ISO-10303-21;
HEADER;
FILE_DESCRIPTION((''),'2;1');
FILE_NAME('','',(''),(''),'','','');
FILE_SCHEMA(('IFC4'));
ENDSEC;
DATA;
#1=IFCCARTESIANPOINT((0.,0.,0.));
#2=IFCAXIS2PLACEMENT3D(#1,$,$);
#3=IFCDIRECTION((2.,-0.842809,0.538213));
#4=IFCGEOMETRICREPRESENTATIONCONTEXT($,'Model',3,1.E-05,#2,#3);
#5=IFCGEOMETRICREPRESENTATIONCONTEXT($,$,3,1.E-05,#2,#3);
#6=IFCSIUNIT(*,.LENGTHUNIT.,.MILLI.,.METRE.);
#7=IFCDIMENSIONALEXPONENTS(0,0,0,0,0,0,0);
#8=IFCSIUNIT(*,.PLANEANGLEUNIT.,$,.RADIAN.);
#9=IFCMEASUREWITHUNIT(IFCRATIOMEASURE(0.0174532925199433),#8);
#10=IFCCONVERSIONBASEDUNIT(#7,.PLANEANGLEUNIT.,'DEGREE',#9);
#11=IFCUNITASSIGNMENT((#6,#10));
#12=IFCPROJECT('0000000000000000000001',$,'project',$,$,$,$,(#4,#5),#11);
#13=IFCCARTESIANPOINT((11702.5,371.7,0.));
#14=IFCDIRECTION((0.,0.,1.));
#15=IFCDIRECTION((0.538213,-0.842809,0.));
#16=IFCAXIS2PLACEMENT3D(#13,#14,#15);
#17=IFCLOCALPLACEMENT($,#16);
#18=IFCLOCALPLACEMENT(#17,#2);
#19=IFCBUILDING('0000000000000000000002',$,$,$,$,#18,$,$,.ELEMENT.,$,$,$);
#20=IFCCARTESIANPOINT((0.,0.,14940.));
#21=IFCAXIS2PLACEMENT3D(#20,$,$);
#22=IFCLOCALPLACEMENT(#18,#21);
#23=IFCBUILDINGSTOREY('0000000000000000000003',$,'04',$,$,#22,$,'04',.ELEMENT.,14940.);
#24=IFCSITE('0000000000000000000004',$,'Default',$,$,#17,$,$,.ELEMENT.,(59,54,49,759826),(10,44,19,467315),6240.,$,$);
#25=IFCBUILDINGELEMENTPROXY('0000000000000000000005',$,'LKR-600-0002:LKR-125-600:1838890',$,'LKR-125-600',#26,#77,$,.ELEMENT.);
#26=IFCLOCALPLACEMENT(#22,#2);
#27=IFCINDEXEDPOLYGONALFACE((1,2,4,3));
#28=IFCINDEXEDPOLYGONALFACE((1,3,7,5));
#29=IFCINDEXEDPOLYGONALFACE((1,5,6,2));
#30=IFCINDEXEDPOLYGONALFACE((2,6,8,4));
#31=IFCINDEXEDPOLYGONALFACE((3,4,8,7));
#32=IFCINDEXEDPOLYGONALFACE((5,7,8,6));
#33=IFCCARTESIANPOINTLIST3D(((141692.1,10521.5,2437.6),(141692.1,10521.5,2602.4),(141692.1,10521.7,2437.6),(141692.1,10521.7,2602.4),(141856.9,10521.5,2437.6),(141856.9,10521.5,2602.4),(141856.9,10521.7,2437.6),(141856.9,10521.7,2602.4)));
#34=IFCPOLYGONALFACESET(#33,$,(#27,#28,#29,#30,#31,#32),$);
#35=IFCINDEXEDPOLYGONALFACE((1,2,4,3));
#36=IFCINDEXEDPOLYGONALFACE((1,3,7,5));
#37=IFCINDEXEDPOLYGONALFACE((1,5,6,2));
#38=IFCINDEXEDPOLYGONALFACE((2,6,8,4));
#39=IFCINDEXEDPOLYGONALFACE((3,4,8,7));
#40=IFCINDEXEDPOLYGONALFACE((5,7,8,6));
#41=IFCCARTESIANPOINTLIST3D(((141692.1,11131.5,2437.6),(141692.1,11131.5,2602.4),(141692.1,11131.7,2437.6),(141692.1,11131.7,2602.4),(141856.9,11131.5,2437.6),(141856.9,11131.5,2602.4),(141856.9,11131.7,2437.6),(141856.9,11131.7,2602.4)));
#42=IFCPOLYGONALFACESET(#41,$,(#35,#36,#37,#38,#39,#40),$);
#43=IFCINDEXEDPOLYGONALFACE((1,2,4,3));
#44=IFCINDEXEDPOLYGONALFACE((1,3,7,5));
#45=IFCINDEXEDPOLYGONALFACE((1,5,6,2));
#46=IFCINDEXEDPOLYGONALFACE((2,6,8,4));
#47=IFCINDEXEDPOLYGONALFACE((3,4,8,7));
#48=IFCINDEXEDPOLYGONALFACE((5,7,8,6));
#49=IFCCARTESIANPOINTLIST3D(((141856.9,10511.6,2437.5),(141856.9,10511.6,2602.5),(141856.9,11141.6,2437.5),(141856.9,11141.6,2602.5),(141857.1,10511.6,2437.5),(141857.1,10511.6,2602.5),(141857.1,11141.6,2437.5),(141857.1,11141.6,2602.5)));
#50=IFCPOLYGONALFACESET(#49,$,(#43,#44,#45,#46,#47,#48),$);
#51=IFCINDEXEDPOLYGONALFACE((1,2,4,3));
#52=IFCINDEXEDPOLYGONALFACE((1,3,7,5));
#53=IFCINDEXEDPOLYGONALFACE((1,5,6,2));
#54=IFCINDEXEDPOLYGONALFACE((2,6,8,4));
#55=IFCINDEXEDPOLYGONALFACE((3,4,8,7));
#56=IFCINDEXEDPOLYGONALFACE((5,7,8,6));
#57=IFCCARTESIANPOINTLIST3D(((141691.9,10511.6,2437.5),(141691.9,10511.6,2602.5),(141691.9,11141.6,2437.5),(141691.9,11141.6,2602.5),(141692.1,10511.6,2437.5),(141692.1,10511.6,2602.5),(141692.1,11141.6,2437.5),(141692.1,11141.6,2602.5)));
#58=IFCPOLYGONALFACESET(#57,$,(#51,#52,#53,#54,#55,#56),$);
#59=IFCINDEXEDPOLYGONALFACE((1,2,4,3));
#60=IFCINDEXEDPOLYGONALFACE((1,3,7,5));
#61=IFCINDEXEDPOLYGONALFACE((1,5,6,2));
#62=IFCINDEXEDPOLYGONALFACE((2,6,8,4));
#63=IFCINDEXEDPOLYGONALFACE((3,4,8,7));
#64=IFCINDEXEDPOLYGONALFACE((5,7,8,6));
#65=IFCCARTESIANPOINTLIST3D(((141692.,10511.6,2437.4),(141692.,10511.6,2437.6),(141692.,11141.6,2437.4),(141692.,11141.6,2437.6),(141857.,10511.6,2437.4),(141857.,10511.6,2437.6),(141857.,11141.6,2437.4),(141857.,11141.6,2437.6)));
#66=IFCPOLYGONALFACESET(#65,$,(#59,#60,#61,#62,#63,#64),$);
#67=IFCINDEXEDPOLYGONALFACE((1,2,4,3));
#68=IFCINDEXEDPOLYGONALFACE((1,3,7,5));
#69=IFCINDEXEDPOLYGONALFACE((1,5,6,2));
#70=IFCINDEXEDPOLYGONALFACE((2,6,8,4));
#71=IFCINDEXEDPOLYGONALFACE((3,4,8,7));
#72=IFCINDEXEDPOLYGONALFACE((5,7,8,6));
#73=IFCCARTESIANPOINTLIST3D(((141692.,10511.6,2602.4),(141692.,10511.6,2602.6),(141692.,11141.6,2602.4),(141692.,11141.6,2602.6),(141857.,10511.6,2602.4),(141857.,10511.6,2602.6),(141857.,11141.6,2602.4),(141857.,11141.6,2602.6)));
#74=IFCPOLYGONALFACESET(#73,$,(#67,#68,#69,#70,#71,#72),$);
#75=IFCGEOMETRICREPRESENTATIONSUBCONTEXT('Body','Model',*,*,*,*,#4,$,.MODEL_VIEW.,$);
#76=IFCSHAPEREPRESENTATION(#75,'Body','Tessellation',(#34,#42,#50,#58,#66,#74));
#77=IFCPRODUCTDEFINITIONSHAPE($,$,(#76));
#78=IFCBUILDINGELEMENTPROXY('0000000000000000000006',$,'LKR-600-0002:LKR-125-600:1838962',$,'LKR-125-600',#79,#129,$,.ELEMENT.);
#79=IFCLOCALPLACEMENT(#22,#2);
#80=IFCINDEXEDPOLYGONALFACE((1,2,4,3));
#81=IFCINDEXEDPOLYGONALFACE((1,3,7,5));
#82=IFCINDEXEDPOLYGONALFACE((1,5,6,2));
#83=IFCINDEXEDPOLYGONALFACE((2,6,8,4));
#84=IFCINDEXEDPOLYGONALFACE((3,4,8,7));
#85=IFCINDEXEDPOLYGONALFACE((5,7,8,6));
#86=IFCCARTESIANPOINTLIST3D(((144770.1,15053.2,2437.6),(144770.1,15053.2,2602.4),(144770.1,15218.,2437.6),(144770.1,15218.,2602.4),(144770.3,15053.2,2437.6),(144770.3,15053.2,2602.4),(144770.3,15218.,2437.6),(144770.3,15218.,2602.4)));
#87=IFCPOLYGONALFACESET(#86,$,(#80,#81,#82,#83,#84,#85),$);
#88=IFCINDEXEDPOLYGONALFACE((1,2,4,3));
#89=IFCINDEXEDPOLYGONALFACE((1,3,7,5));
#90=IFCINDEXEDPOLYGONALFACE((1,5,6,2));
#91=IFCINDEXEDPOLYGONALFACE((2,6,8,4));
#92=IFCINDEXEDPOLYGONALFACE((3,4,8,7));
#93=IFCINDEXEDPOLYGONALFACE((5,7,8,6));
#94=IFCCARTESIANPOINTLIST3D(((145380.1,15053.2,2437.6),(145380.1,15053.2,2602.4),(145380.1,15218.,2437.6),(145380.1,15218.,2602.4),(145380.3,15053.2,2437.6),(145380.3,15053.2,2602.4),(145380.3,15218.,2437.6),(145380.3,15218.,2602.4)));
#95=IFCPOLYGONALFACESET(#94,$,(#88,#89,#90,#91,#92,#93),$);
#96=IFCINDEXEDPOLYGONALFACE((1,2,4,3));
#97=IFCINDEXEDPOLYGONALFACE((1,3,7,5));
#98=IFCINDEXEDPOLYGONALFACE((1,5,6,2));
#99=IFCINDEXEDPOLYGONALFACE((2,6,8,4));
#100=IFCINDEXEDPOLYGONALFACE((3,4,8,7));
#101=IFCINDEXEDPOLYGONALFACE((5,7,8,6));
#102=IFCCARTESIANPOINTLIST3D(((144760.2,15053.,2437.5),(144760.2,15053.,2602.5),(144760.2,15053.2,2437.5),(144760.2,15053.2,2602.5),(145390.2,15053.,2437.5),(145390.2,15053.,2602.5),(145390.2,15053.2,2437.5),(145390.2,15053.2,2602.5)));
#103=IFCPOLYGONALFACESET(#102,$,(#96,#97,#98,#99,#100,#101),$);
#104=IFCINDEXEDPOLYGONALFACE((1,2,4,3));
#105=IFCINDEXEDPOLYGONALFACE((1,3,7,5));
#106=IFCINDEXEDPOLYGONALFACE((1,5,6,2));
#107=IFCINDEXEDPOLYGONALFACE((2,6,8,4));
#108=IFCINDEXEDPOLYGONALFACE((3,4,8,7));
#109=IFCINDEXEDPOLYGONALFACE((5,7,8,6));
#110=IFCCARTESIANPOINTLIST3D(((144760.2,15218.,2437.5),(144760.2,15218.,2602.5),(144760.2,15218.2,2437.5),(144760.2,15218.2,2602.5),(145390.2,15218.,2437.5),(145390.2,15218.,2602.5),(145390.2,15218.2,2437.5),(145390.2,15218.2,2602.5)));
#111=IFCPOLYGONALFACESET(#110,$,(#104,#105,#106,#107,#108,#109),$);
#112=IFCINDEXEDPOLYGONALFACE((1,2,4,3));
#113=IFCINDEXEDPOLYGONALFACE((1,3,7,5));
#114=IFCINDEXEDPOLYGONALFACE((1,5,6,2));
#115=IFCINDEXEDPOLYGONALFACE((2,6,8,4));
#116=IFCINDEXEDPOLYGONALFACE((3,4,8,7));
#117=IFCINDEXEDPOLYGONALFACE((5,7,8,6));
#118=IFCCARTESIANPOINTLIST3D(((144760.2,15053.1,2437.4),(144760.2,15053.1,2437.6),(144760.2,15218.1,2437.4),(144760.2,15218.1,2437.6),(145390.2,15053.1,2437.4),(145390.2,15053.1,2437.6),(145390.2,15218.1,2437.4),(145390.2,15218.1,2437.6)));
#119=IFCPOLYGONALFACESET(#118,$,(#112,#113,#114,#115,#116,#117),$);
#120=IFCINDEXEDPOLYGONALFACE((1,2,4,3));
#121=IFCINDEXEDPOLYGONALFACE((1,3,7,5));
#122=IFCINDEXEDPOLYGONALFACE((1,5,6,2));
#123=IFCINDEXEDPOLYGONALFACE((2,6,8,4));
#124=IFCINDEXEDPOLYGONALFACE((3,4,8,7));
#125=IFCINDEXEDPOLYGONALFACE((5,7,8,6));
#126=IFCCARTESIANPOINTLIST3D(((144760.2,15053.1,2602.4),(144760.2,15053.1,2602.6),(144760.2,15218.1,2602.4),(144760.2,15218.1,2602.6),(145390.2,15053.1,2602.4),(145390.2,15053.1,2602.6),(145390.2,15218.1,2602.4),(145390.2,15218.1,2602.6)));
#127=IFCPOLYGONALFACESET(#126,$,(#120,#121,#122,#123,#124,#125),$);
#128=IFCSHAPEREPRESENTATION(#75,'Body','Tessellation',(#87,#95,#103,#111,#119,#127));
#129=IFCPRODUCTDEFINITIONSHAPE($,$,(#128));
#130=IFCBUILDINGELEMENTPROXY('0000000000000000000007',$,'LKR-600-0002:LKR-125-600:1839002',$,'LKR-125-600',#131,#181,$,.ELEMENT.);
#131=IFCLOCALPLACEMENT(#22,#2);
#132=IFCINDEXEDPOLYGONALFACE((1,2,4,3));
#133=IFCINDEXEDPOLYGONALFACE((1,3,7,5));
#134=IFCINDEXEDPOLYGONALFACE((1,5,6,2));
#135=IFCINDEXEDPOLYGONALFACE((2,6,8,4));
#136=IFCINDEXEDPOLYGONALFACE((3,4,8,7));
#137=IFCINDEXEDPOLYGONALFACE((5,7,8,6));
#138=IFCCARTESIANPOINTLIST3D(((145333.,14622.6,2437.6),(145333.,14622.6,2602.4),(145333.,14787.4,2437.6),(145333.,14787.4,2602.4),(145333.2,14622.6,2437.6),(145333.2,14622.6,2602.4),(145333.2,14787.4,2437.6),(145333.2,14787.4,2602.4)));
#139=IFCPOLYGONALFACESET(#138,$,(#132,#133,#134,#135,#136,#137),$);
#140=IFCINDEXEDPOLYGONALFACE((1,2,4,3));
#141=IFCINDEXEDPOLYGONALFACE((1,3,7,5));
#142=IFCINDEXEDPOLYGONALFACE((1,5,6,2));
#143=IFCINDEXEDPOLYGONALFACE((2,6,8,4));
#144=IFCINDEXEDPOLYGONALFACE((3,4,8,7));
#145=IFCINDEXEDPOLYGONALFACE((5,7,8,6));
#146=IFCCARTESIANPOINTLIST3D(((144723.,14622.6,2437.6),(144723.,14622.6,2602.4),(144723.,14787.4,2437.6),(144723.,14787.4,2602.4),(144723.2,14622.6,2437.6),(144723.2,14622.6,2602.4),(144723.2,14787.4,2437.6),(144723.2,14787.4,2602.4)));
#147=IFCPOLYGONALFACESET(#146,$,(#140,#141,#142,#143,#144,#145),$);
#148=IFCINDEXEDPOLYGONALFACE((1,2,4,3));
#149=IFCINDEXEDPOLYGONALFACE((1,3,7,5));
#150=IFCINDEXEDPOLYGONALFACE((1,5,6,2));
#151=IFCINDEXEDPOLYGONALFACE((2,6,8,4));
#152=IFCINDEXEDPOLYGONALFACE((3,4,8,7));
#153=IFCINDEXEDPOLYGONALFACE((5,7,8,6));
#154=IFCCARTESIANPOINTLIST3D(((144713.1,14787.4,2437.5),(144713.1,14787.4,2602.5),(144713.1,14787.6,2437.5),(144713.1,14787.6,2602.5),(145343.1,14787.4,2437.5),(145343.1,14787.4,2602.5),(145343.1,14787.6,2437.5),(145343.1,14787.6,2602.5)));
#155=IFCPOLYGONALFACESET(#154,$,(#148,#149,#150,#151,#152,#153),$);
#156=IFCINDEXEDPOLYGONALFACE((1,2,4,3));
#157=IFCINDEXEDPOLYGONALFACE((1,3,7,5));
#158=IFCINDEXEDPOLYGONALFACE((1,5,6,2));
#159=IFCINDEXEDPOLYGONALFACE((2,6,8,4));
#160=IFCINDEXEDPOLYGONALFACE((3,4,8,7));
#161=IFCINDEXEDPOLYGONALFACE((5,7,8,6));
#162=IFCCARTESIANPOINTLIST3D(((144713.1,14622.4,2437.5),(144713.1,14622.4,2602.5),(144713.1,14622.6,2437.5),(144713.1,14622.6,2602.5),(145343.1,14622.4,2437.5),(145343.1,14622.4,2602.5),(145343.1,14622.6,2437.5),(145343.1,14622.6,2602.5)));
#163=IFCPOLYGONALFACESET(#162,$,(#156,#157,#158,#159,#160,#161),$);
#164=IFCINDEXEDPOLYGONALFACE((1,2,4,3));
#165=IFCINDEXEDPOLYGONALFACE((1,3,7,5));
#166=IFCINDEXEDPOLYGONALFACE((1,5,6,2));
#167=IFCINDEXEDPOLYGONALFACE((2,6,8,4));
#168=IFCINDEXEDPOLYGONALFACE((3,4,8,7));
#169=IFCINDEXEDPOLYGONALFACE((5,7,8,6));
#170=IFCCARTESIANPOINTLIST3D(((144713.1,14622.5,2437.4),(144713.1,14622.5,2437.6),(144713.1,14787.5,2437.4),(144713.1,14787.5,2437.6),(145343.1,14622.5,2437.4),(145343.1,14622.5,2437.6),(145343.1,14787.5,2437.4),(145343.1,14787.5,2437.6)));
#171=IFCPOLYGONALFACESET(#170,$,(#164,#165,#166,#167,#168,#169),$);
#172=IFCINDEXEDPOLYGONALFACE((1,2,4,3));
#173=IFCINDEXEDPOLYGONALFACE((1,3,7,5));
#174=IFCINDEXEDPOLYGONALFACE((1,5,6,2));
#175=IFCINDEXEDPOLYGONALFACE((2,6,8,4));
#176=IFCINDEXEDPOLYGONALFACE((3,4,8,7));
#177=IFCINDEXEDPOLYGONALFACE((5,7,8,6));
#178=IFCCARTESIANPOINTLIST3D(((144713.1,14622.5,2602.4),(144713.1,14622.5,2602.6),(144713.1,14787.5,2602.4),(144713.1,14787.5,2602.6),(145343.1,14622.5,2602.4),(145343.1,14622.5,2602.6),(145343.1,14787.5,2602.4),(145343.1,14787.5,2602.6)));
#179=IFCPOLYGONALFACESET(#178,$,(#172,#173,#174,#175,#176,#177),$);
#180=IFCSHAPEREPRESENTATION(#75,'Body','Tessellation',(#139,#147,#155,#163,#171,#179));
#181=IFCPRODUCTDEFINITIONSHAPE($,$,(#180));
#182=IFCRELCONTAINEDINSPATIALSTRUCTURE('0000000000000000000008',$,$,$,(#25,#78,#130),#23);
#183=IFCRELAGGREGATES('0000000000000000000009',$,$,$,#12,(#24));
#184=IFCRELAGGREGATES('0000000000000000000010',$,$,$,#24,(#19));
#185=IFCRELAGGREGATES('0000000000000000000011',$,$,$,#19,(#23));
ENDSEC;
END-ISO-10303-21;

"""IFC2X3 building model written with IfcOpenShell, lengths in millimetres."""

from ifc_helpers import new_model, entity, si_unit, converted_unit, direction, frame, frame_2d, origin, place, context, subcontext, project, spatial, rectangle, extrude, source, transform, mapped, element, save


model = new_model("IFC2X3")

# Units and contexts
model_context = context("Model", 3, precision=1e-05, world=origin(), true_north=direction((2.0, -0.842809, 0.538213)))
context_of_model = context(None, 3, precision=1e-05, world=origin(), true_north=direction((2.0, -0.842809, 0.538213)))
body_context = subcontext(model_context, "Body", "Model", "MODEL_VIEW")
ifc_project = project(units=[si_unit("LENGTHUNIT", "METRE", prefix="MILLI"), converted_unit("PLANEANGLEUNIT", "DEGREE", entity("IfcRatioMeasure", 0.0174532925199433), si_unit("PLANEANGLEUNIT", "RADIAN"), dimensions=[0, 0, 0, 0, 0, 0, 0])], contexts=[model_context, context_of_model])

# Site, building, storey
site_placement = place(None, frame((11702.5, 371.7, 0.0), z_axis=(0.0, 0.0, 1.0), x_axis=(0.538213, -0.842809, 0.0)))
site = spatial("IfcSite", under=ifc_project, at=site_placement, Name="Default", CompositionType="ELEMENT", RefLatitude=(59, 54, 49, 759826), RefLongitude=(10, 44, 19, 467315), RefElevation=6240.0)
building_placement = place(site_placement, origin())
building = spatial("IfcBuilding", under=site, at=building_placement, CompositionType="ELEMENT")
storey_placement = place(building_placement, frame((0.0, 0.0, 14940.0)))
storey = spatial("IfcBuildingStorey", under=building, at=storey_placement, Name="04", LongName="04", CompositionType="ELEMENT", Elevation=14940.0)

# Building element proxies
shared_shape_1 = source(origin(), body_context, "Body", "SweptSolid", [
    extrude(rectangle(XDim=0.2, YDim=164.8, at=frame_2d((0.0, 0.0), x_axis=(1.0, 0.0))), frame((305.0, 0.0, -82.4)), (0.0, 0.0, 1.0), 164.8),
    extrude(rectangle(XDim=0.2, YDim=164.8, at=frame_2d((0.0, 0.0), x_axis=(1.0, 0.0))), frame((-305.0, 0.0, -82.4)), (0.0, 0.0, 1.0), 164.8),
    extrude(rectangle(XDim=0.2, YDim=630.0, at=frame_2d((0.0, 0.0), x_axis=(1.0, 0.0))), frame((0.0, 82.5, -82.5), z_axis=(0.0, 0.0, 1.0), x_axis=(0.0, 1.0, 0.0)), (0.0, 0.0, 1.0), 165.0),
    extrude(rectangle(XDim=0.2, YDim=630.0, at=frame_2d((0.0, 0.0), x_axis=(1.0, 0.0))), frame((0.0, -82.5, -82.5), z_axis=(0.0, 0.0, 1.0), x_axis=(0.0, 1.0, 0.0)), (0.0, 0.0, 1.0), 165.0),
    extrude(rectangle(XDim=165.0, YDim=630.0, at=frame_2d((0.0, 0.0), x_axis=(1.0, 0.0))), frame((0.0, 0.0, -82.6), z_axis=(0.0, 0.0, 1.0), x_axis=(0.0, -1.0, 0.0)), (0.0, 0.0, 1.0), 0.2),
    extrude(rectangle(XDim=165.0, YDim=630.0, at=frame_2d((0.0, 0.0), x_axis=(1.0, 0.0))), frame((0.0, 0.0, 82.4), z_axis=(0.0, 0.0, 1.0), x_axis=(0.0, -1.0, 0.0)), (0.0, 0.0, 1.0), 0.2),
])
for number, where, z_axis, x_axis, name in (
    (1, (141774.5, 10826.6, 2520.0), (0.0, 0.0, 1.0), (0.0, -1.0, 0.0), "LKR-600-0002:LKR-125-600:1838890"),
    (2, (145075.2, 15135.6, 2520.0), (0.0, 0.0, 1.0), (-1.0, 0.0, 0.0), "LKR-600-0002:LKR-125-600:1838962"),
):
    element("IfcBuildingElementProxy", number, at=place(storey_placement, frame(where, z_axis=z_axis, x_axis=x_axis)), inside=storey, Name=name, ObjectType="LKR-125-600", CompositionType="ELEMENT", context=body_context, shape_type="MappedRepresentation", body=[
        mapped(shared_shape_1, transform((0.0, 0.0, 0.0), scale=1.0)),
    ])
proxy_placement = place(storey_placement, frame((145028.1, 14705.0, 2520.0)))
element("IfcBuildingElementProxy", 3, at=proxy_placement, inside=storey, Name="LKR-600-0002:LKR-125-600:1839002", ObjectType="LKR-125-600", CompositionType="ELEMENT", context=body_context, shape_type="MappedRepresentation", body=[
    mapped(shared_shape_1, transform((0.0, 0.0, 0.0), scale=1.0)),
])

save(model, "model.ifc")
